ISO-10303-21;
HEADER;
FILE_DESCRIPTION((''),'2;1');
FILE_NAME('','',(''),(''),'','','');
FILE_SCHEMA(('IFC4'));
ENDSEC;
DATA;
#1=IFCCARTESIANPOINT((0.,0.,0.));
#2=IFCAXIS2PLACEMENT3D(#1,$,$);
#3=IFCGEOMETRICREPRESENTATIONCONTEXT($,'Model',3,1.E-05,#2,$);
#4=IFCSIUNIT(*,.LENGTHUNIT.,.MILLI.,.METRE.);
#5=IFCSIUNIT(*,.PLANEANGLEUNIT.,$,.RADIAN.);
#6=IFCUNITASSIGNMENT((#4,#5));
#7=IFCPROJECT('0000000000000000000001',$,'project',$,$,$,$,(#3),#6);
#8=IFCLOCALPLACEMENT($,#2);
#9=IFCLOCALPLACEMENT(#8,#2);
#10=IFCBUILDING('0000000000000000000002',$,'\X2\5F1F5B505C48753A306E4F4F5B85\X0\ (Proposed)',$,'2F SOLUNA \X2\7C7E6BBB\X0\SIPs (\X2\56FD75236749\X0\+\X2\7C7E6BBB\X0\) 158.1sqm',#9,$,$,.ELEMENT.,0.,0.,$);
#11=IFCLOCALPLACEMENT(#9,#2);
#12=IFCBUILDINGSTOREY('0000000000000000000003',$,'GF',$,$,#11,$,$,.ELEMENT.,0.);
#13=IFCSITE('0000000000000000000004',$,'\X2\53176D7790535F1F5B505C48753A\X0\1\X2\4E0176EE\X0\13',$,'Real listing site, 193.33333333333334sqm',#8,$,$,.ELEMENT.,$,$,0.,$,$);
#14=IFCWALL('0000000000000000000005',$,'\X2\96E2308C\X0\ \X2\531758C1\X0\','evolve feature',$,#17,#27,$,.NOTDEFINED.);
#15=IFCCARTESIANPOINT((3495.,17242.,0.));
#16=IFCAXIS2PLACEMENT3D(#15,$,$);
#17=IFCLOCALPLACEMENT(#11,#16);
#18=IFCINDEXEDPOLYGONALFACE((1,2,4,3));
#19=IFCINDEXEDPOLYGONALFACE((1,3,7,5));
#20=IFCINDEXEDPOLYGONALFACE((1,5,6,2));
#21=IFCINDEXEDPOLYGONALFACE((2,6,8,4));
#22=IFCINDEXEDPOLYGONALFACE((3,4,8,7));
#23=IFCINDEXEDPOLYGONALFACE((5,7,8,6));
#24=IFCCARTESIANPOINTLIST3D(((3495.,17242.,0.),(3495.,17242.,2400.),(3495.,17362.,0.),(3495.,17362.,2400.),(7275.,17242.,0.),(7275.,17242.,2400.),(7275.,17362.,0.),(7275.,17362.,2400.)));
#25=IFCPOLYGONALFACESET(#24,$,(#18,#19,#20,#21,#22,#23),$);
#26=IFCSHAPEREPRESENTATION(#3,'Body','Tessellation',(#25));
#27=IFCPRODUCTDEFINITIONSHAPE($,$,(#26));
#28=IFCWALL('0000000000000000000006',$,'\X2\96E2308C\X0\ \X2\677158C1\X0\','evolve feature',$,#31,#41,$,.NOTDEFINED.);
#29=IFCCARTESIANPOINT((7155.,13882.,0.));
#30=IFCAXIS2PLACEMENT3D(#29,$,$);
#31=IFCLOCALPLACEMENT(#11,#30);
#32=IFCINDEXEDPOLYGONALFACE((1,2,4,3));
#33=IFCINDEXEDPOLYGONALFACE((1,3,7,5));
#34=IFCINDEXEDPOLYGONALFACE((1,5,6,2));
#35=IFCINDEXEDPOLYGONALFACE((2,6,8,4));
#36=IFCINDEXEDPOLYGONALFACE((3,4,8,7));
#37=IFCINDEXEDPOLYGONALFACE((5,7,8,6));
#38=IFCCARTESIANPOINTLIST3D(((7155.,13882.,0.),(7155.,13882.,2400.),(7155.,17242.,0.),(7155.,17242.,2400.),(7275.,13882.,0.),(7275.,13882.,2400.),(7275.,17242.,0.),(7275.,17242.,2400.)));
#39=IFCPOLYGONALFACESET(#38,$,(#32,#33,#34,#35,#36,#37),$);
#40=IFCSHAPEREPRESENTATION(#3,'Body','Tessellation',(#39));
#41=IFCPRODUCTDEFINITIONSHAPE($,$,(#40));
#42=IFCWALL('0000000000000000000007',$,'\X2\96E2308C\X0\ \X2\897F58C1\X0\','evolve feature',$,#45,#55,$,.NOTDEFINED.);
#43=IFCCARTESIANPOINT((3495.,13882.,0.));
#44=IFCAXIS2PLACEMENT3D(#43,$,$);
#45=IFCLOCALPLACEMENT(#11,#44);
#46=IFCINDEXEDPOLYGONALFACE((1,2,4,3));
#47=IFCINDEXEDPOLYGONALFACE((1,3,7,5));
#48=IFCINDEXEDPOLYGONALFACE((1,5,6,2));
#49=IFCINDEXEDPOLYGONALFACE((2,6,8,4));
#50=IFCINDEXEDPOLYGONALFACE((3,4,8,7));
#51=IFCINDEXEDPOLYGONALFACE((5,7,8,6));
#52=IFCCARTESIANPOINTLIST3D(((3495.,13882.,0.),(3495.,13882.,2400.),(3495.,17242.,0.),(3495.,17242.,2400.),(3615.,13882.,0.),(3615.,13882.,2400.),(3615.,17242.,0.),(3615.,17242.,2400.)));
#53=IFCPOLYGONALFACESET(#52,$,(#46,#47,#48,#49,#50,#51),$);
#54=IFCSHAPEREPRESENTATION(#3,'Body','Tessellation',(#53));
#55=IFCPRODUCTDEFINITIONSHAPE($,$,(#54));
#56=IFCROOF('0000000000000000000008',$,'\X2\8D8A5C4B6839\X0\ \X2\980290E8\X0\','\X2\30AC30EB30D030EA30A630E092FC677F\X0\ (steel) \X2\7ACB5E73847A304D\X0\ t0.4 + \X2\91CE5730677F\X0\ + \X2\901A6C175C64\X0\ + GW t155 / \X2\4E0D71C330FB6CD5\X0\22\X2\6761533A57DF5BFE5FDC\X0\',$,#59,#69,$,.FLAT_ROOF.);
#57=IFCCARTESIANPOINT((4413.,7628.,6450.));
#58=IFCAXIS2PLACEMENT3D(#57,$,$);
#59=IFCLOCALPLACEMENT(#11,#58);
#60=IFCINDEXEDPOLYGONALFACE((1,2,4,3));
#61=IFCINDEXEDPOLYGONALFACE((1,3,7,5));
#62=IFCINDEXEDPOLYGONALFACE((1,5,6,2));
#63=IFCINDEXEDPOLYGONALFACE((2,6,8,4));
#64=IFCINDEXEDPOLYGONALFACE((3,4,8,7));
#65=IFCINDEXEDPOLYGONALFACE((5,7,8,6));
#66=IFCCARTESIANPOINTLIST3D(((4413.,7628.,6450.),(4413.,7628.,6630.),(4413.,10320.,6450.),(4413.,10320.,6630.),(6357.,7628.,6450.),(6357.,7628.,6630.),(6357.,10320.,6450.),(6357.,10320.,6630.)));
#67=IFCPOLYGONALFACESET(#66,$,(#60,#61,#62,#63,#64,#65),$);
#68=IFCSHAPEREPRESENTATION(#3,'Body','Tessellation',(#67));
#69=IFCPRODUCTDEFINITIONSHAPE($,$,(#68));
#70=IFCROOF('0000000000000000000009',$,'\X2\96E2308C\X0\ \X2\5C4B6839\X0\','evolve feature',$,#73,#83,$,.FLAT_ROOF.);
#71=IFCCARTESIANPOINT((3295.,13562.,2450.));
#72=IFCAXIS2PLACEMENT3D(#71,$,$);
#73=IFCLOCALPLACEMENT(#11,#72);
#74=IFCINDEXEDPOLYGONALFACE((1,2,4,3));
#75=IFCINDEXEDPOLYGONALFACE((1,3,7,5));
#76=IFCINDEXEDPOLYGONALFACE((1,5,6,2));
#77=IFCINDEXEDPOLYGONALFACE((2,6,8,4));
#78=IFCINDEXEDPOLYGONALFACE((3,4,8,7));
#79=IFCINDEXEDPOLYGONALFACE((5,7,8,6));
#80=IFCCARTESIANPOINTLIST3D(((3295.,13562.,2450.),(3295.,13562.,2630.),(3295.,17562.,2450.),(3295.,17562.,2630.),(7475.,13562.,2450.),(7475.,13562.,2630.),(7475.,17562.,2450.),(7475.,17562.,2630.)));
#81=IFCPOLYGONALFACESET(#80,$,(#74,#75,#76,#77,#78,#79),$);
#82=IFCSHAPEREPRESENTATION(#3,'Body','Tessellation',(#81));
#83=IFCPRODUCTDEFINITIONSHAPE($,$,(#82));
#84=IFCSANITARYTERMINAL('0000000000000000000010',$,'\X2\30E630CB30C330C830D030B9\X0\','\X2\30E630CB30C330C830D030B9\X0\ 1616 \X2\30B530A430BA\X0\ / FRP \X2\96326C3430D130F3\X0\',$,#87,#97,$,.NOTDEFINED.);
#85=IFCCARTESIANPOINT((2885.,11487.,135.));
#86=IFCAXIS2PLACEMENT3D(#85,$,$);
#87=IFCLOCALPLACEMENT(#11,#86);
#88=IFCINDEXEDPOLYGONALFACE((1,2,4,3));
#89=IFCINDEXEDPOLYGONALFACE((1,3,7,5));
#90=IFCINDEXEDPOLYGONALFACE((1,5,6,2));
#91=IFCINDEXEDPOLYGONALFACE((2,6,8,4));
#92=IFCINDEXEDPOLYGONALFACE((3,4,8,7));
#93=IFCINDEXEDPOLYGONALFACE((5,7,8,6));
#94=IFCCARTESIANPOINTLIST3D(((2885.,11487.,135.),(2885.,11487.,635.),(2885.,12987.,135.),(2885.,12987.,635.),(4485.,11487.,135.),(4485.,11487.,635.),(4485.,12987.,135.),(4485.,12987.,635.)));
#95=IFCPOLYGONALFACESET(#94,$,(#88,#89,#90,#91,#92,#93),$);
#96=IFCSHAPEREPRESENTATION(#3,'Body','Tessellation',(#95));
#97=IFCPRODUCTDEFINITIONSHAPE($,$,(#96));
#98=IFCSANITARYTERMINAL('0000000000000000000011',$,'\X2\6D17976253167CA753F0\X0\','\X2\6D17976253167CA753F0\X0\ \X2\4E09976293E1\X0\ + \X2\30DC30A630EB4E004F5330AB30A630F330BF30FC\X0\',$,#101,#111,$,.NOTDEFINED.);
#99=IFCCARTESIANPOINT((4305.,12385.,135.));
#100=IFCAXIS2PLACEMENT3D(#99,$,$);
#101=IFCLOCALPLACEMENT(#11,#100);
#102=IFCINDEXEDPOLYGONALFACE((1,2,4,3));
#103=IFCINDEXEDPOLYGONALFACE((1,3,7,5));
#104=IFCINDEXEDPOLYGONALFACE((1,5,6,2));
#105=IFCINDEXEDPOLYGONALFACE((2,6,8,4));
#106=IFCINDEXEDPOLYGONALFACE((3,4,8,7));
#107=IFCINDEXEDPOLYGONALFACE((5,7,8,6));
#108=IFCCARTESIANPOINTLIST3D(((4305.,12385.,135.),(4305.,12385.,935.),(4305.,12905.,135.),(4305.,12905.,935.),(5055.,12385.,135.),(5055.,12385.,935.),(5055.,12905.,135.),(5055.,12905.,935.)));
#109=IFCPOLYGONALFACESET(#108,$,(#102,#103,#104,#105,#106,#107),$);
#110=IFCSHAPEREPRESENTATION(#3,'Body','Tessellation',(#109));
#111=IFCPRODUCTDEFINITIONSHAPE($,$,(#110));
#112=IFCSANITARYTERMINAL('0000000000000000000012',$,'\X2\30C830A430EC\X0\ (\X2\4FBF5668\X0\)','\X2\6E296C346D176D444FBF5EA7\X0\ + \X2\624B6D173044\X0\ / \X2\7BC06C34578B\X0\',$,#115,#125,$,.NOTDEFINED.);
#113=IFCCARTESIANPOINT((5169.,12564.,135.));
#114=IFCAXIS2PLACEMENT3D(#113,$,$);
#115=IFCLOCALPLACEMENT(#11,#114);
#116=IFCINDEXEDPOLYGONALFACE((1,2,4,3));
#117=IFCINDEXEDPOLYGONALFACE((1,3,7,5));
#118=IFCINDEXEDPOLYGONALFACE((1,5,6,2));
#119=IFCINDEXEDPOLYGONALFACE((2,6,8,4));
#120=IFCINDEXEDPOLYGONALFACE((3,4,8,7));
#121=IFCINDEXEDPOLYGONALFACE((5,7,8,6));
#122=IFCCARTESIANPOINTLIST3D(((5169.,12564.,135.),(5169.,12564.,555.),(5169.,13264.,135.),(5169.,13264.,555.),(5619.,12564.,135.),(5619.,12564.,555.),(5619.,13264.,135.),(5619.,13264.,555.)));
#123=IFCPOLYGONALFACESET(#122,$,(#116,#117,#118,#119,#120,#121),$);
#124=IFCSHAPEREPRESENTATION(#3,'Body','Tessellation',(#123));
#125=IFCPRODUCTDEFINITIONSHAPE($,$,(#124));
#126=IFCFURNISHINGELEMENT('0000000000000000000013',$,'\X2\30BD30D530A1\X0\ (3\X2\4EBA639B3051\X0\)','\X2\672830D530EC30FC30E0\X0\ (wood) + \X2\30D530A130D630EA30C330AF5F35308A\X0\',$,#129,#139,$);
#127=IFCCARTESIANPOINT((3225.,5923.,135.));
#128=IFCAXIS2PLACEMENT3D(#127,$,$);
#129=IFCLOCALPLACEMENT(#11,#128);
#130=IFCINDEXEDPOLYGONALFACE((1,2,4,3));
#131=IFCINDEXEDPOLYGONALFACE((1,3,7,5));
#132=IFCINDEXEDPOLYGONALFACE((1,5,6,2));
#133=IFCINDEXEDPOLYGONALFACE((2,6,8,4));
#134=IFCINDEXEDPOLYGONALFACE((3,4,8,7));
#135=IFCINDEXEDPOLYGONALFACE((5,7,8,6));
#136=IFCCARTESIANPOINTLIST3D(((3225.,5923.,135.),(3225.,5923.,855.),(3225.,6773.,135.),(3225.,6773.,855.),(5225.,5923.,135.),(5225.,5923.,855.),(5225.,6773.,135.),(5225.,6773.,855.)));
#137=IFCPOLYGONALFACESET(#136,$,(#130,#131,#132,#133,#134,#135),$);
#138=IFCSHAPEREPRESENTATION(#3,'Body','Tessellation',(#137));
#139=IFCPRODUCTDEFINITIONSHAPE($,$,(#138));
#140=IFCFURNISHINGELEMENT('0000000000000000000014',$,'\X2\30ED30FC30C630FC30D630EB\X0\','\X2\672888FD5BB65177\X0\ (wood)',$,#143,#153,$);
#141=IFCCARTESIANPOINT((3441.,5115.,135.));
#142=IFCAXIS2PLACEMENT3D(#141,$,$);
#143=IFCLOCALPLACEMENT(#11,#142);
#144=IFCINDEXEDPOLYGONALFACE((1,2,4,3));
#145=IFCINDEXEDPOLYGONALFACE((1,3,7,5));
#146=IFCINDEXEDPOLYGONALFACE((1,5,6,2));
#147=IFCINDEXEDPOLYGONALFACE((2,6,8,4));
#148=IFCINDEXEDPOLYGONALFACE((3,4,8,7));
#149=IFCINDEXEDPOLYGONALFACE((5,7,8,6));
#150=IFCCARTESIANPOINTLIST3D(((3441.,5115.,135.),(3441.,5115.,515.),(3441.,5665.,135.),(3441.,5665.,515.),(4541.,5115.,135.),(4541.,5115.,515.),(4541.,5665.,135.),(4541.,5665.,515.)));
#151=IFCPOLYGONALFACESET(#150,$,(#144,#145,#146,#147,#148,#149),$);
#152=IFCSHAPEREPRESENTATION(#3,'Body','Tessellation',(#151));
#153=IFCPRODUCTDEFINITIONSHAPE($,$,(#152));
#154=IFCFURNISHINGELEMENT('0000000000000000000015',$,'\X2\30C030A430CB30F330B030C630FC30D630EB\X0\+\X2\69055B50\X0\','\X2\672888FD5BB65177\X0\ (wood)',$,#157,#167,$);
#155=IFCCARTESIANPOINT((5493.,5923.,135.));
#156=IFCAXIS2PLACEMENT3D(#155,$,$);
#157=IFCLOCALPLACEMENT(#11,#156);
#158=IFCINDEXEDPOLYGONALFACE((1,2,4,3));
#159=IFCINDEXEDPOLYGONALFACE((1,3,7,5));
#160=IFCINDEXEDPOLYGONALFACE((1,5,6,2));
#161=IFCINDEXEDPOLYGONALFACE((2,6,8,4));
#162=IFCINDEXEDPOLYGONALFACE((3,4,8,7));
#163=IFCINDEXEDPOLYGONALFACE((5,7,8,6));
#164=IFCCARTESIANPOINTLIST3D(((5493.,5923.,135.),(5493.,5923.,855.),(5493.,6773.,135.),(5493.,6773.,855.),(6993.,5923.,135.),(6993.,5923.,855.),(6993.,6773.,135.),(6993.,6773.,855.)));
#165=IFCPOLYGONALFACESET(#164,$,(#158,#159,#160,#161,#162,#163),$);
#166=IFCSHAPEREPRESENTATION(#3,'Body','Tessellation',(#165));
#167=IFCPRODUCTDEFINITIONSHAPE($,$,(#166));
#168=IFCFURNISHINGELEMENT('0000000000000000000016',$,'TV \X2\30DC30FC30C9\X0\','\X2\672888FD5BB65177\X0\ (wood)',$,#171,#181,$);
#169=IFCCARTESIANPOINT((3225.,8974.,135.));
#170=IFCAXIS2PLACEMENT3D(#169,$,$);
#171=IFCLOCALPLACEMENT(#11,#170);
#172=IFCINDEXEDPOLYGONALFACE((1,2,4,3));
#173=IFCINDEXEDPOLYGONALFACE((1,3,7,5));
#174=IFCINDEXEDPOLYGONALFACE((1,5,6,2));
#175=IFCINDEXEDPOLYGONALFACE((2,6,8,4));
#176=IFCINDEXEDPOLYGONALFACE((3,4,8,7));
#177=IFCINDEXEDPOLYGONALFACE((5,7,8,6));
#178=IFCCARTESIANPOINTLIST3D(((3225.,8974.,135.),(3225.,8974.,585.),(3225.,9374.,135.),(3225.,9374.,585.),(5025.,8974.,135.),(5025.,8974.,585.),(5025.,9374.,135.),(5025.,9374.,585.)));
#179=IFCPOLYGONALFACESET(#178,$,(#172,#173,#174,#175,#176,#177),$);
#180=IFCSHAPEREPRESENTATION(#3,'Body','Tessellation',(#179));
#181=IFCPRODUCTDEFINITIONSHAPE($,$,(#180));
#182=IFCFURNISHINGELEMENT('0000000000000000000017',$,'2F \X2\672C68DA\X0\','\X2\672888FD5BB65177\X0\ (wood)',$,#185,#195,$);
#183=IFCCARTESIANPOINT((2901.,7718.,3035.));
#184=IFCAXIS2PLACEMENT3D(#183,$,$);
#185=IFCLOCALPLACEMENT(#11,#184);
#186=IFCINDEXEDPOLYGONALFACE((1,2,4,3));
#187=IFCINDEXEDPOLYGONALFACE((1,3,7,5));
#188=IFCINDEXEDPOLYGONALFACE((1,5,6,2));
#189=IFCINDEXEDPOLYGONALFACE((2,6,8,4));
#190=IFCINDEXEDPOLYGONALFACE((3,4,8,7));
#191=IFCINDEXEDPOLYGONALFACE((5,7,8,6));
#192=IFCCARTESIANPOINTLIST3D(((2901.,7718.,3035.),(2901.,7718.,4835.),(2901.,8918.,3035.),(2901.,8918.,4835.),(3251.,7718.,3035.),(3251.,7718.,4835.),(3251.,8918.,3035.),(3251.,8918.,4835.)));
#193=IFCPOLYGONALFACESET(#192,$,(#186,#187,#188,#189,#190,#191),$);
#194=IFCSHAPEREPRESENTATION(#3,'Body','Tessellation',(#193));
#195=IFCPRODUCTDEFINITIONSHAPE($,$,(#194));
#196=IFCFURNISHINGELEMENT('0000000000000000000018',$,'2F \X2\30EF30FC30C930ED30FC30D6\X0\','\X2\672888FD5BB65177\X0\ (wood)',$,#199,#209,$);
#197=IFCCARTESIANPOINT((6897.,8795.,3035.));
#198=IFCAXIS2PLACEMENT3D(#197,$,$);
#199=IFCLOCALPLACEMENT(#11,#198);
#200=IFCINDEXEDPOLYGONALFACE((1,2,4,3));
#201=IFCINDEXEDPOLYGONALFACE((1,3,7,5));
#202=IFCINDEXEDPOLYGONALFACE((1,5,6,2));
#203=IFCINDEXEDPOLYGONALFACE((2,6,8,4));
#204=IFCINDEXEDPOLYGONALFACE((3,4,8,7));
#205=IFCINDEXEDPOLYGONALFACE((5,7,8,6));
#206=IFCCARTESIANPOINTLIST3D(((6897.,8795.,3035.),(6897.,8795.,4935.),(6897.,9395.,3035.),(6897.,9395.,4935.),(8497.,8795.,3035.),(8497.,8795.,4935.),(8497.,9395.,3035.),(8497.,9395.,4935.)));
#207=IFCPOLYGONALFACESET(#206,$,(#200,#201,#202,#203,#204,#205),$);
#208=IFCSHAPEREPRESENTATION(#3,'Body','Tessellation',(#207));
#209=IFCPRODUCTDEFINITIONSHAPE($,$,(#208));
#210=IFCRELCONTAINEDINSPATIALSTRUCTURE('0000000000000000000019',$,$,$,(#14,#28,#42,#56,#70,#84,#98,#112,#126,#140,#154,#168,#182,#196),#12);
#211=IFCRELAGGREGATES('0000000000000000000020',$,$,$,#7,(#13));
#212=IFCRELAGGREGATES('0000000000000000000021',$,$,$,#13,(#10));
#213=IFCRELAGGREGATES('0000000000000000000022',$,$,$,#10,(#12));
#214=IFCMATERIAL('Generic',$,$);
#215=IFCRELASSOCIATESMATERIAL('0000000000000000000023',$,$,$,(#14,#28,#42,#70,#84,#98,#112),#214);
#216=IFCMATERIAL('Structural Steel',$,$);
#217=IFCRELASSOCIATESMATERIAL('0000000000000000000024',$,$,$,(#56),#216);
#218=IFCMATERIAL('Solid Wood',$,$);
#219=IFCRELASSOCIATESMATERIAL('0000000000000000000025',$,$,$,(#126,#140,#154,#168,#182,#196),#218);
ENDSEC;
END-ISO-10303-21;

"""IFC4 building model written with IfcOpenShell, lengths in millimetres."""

from ifc_helpers import new_model, si_unit, frame, frame_2d, origin, place, context, project, spatial, rectangle, extrude, material, element, save


model = new_model("IFC4")

# Units and contexts
model_context = context("Model", 3, precision=1e-05, world=origin())
ifc_project = project(units=[si_unit("LENGTHUNIT", "METRE", prefix="MILLI"), si_unit("PLANEANGLEUNIT", "RADIAN")], contexts=[model_context])

# Site, building, storey
site_placement = place(None, origin())
site = spatial("IfcSite", under=ifc_project, at=site_placement, Name="北海道弟子屈町1丁目13", ObjectType="Real listing site, 193.33333333333334sqm", CompositionType="ELEMENT", RefElevation=0.0)
building_placement = place(site_placement, origin())
building = spatial("IfcBuilding", under=site, at=building_placement, Name="弟子屈町の住宅 (Proposed)", ObjectType="2F SOLUNA 籾殻SIPs (国産杉+籾殻) 158.1sqm", CompositionType="ELEMENT", ElevationOfRefHeight=0.0, ElevationOfTerrain=0.0)
storey_placement = place(building_placement, origin())
storey = spatial("IfcBuildingStorey", under=building, at=storey_placement, Name="GF", CompositionType="ELEMENT", Elevation=0.0)

# Shared definitions
ifc_material_1 = material(Name="Generic")

# Shared definitions
ifc_material_2 = material(Name="Solid Wood")

# Walls
wall_1_placement = place(storey_placement, frame((3495.0, 17242.0, 0.0)))
element("IfcWall", 1, at=wall_1_placement, inside=storey, material=ifc_material_1, Name="離れ 北壁", Description="evolve feature", PredefinedType="NOTDEFINED", context=model_context, shape_type="SweptSolid", body=[
    extrude(rectangle(XDim=3780.0, YDim=120.0, at=frame_2d((1890.0, 60.0))), frame((3495.0, 17242.0, 0.0)), (0.0, 0.0, 1.0), 2400.0),
])
wall_2_placement = place(storey_placement, frame((7155.0, 13882.0, 0.0)))
element("IfcWall", 2, at=wall_2_placement, inside=storey, material=ifc_material_1, Name="離れ 東壁", Description="evolve feature", PredefinedType="NOTDEFINED", context=model_context, shape_type="SweptSolid", body=[
    extrude(rectangle(XDim=120.0, YDim=3360.0, at=frame_2d((60.0, 1680.0))), frame((7155.0, 13882.0, 0.0)), (0.0, 0.0, 1.0), 2400.0),
])
wall_3_placement = place(storey_placement, frame((3495.0, 13882.0, 0.0)))
element("IfcWall", 3, at=wall_3_placement, inside=storey, material=ifc_material_1, Name="離れ 西壁", Description="evolve feature", PredefinedType="NOTDEFINED", context=model_context, shape_type="SweptSolid", body=[
    extrude(rectangle(XDim=120.0, YDim=3360.0, at=frame_2d((60.0, 1680.0))), frame((3495.0, 13882.0, 0.0)), (0.0, 0.0, 1.0), 2400.0),
])

# Roofs
ifc_material_3 = material(Name="Structural Steel")
roof_1_placement = place(storey_placement, frame((4413.0, 7628.0, 6450.0)))
element("IfcRoof", 4, at=roof_1_placement, inside=storey, material=ifc_material_3, Name="越屋根 頂部", Description="ガルバリウム鋼板 (steel) 立平葺き t0.4 + 野地板 + 通気層 + GW t155 / 不燃・法22条区域対応", PredefinedType="FLAT_ROOF", context=model_context, shape_type="SweptSolid", body=[
    extrude(rectangle(XDim=1944.0, YDim=2692.0, at=frame_2d((972.0, 1346.0))), frame((4413.0, 7628.0, 6450.0)), (0.0, 0.0, 1.0), 180.0),
])
roof_2_placement = place(storey_placement, frame((3295.0, 13562.0, 2450.0)))
element("IfcRoof", 5, at=roof_2_placement, inside=storey, material=ifc_material_1, Name="離れ 屋根", Description="evolve feature", PredefinedType="FLAT_ROOF", context=model_context, shape_type="SweptSolid", body=[
    extrude(rectangle(XDim=4180.0, YDim=4000.0, at=frame_2d((2090.0, 2000.0))), frame((3295.0, 13562.0, 2450.0)), (0.0, 0.0, 1.0), 180.0),
])

# Sanitary terminals
sanitary_terminal_1_placement = place(storey_placement, frame((2885.0, 11487.0, 135.0)))
element("IfcSanitaryTerminal", 6, at=sanitary_terminal_1_placement, inside=storey, material=ifc_material_1, Name="ユニットバス", Description="ユニットバス 1616 サイズ / FRP 防水パン", PredefinedType="NOTDEFINED", context=model_context, shape_type="SweptSolid", body=[
    extrude(rectangle(XDim=1600.0, YDim=1500.0, at=frame_2d((800.0, 750.0))), frame((2885.0, 11487.0, 135.0)), (0.0, 0.0, 1.0), 500.0),
])
sanitary_terminal_2_placement = place(storey_placement, frame((4305.0, 12385.0, 135.0)))
element("IfcSanitaryTerminal", 7, at=sanitary_terminal_2_placement, inside=storey, material=ifc_material_1, Name="洗面化粧台", Description="洗面化粧台 三面鏡 + ボウル一体カウンター", PredefinedType="NOTDEFINED", context=model_context, shape_type="SweptSolid", body=[
    extrude(rectangle(XDim=750.0, YDim=520.0, at=frame_2d((375.0, 260.0))), frame((4305.0, 12385.0, 135.0)), (0.0, 0.0, 1.0), 800.0),
])
sanitary_terminal_3_placement = place(storey_placement, frame((5169.0, 12564.0, 135.0)))
element("IfcSanitaryTerminal", 8, at=sanitary_terminal_3_placement, inside=storey, material=ifc_material_1, Name="トイレ (便器)", Description="温水洗浄便座 + 手洗い / 節水型", PredefinedType="NOTDEFINED", context=model_context, shape_type="SweptSolid", body=[
    extrude(rectangle(XDim=450.0, YDim=700.0, at=frame_2d((225.0, 350.0))), frame((5169.0, 12564.0, 135.0)), (0.0, 0.0, 1.0), 420.0),
])

# Furnishing elements
furnishing_1_placement = place(storey_placement, frame((3225.0, 5923.0, 135.0)))
element("IfcFurnishingElement", 9, at=furnishing_1_placement, inside=storey, material=ifc_material_2, Name="ソファ (3人掛け)", Description="木フレーム (wood) + ファブリック張り", context=model_context, shape_type="SweptSolid", body=[
    extrude(rectangle(XDim=2000.0, YDim=850.0, at=frame_2d((1000.0, 425.0))), frame((3225.0, 5923.0, 135.0)), (0.0, 0.0, 1.0), 720.0),
])
furnishing_2_placement = place(storey_placement, frame((3441.0, 5115.0, 135.0)))
element("IfcFurnishingElement", 10, at=furnishing_2_placement, inside=storey, material=ifc_material_2, Name="ローテーブル", Description="木製家具 (wood)", context=model_context, shape_type="SweptSolid", body=[
    extrude(rectangle(XDim=1100.0, YDim=550.0, at=frame_2d((550.0, 275.0))), frame((3441.0, 5115.0, 135.0)), (0.0, 0.0, 1.0), 380.0),
])
furnishing_3_placement = place(storey_placement, frame((5493.0, 5923.0, 135.0)))
element("IfcFurnishingElement", 11, at=furnishing_3_placement, inside=storey, material=ifc_material_2, Name="ダイニングテーブル+椅子", Description="木製家具 (wood)", context=model_context, shape_type="SweptSolid", body=[
    extrude(rectangle(XDim=1500.0, YDim=850.0, at=frame_2d((750.0, 425.0))), frame((5493.0, 5923.0, 135.0)), (0.0, 0.0, 1.0), 720.0),
])
furnishing_4_placement = place(storey_placement, frame((3225.0, 8974.0, 135.0)))
element("IfcFurnishingElement", 12, at=furnishing_4_placement, inside=storey, material=ifc_material_2, Name="TV ボード", Description="木製家具 (wood)", context=model_context, shape_type="SweptSolid", body=[
    extrude(rectangle(XDim=1800.0, YDim=400.0, at=frame_2d((900.0, 200.0))), frame((3225.0, 8974.0, 135.0)), (0.0, 0.0, 1.0), 450.0),
])
furnishing_5_placement = place(storey_placement, frame((2901.0, 7718.0, 3035.0)))
element("IfcFurnishingElement", 13, at=furnishing_5_placement, inside=storey, material=ifc_material_2, Name="2F 本棚", Description="木製家具 (wood)", context=model_context, shape_type="SweptSolid", body=[
    extrude(rectangle(XDim=350.0, YDim=1200.0, at=frame_2d((175.0, 600.0))), frame((2901.0, 7718.0, 3035.0)), (0.0, 0.0, 1.0), 1800.0),
])
furnishing_6_placement = place(storey_placement, frame((6897.0, 8795.0, 3035.0)))
element("IfcFurnishingElement", 14, at=furnishing_6_placement, inside=storey, material=ifc_material_2, Name="2F ワードローブ", Description="木製家具 (wood)", context=model_context, shape_type="SweptSolid", body=[
    extrude(rectangle(XDim=1600.0, YDim=600.0, at=frame_2d((800.0, 300.0))), frame((6897.0, 8795.0, 3035.0)), (0.0, 0.0, 1.0), 1900.0),
])

save(model, "model.ifc")
